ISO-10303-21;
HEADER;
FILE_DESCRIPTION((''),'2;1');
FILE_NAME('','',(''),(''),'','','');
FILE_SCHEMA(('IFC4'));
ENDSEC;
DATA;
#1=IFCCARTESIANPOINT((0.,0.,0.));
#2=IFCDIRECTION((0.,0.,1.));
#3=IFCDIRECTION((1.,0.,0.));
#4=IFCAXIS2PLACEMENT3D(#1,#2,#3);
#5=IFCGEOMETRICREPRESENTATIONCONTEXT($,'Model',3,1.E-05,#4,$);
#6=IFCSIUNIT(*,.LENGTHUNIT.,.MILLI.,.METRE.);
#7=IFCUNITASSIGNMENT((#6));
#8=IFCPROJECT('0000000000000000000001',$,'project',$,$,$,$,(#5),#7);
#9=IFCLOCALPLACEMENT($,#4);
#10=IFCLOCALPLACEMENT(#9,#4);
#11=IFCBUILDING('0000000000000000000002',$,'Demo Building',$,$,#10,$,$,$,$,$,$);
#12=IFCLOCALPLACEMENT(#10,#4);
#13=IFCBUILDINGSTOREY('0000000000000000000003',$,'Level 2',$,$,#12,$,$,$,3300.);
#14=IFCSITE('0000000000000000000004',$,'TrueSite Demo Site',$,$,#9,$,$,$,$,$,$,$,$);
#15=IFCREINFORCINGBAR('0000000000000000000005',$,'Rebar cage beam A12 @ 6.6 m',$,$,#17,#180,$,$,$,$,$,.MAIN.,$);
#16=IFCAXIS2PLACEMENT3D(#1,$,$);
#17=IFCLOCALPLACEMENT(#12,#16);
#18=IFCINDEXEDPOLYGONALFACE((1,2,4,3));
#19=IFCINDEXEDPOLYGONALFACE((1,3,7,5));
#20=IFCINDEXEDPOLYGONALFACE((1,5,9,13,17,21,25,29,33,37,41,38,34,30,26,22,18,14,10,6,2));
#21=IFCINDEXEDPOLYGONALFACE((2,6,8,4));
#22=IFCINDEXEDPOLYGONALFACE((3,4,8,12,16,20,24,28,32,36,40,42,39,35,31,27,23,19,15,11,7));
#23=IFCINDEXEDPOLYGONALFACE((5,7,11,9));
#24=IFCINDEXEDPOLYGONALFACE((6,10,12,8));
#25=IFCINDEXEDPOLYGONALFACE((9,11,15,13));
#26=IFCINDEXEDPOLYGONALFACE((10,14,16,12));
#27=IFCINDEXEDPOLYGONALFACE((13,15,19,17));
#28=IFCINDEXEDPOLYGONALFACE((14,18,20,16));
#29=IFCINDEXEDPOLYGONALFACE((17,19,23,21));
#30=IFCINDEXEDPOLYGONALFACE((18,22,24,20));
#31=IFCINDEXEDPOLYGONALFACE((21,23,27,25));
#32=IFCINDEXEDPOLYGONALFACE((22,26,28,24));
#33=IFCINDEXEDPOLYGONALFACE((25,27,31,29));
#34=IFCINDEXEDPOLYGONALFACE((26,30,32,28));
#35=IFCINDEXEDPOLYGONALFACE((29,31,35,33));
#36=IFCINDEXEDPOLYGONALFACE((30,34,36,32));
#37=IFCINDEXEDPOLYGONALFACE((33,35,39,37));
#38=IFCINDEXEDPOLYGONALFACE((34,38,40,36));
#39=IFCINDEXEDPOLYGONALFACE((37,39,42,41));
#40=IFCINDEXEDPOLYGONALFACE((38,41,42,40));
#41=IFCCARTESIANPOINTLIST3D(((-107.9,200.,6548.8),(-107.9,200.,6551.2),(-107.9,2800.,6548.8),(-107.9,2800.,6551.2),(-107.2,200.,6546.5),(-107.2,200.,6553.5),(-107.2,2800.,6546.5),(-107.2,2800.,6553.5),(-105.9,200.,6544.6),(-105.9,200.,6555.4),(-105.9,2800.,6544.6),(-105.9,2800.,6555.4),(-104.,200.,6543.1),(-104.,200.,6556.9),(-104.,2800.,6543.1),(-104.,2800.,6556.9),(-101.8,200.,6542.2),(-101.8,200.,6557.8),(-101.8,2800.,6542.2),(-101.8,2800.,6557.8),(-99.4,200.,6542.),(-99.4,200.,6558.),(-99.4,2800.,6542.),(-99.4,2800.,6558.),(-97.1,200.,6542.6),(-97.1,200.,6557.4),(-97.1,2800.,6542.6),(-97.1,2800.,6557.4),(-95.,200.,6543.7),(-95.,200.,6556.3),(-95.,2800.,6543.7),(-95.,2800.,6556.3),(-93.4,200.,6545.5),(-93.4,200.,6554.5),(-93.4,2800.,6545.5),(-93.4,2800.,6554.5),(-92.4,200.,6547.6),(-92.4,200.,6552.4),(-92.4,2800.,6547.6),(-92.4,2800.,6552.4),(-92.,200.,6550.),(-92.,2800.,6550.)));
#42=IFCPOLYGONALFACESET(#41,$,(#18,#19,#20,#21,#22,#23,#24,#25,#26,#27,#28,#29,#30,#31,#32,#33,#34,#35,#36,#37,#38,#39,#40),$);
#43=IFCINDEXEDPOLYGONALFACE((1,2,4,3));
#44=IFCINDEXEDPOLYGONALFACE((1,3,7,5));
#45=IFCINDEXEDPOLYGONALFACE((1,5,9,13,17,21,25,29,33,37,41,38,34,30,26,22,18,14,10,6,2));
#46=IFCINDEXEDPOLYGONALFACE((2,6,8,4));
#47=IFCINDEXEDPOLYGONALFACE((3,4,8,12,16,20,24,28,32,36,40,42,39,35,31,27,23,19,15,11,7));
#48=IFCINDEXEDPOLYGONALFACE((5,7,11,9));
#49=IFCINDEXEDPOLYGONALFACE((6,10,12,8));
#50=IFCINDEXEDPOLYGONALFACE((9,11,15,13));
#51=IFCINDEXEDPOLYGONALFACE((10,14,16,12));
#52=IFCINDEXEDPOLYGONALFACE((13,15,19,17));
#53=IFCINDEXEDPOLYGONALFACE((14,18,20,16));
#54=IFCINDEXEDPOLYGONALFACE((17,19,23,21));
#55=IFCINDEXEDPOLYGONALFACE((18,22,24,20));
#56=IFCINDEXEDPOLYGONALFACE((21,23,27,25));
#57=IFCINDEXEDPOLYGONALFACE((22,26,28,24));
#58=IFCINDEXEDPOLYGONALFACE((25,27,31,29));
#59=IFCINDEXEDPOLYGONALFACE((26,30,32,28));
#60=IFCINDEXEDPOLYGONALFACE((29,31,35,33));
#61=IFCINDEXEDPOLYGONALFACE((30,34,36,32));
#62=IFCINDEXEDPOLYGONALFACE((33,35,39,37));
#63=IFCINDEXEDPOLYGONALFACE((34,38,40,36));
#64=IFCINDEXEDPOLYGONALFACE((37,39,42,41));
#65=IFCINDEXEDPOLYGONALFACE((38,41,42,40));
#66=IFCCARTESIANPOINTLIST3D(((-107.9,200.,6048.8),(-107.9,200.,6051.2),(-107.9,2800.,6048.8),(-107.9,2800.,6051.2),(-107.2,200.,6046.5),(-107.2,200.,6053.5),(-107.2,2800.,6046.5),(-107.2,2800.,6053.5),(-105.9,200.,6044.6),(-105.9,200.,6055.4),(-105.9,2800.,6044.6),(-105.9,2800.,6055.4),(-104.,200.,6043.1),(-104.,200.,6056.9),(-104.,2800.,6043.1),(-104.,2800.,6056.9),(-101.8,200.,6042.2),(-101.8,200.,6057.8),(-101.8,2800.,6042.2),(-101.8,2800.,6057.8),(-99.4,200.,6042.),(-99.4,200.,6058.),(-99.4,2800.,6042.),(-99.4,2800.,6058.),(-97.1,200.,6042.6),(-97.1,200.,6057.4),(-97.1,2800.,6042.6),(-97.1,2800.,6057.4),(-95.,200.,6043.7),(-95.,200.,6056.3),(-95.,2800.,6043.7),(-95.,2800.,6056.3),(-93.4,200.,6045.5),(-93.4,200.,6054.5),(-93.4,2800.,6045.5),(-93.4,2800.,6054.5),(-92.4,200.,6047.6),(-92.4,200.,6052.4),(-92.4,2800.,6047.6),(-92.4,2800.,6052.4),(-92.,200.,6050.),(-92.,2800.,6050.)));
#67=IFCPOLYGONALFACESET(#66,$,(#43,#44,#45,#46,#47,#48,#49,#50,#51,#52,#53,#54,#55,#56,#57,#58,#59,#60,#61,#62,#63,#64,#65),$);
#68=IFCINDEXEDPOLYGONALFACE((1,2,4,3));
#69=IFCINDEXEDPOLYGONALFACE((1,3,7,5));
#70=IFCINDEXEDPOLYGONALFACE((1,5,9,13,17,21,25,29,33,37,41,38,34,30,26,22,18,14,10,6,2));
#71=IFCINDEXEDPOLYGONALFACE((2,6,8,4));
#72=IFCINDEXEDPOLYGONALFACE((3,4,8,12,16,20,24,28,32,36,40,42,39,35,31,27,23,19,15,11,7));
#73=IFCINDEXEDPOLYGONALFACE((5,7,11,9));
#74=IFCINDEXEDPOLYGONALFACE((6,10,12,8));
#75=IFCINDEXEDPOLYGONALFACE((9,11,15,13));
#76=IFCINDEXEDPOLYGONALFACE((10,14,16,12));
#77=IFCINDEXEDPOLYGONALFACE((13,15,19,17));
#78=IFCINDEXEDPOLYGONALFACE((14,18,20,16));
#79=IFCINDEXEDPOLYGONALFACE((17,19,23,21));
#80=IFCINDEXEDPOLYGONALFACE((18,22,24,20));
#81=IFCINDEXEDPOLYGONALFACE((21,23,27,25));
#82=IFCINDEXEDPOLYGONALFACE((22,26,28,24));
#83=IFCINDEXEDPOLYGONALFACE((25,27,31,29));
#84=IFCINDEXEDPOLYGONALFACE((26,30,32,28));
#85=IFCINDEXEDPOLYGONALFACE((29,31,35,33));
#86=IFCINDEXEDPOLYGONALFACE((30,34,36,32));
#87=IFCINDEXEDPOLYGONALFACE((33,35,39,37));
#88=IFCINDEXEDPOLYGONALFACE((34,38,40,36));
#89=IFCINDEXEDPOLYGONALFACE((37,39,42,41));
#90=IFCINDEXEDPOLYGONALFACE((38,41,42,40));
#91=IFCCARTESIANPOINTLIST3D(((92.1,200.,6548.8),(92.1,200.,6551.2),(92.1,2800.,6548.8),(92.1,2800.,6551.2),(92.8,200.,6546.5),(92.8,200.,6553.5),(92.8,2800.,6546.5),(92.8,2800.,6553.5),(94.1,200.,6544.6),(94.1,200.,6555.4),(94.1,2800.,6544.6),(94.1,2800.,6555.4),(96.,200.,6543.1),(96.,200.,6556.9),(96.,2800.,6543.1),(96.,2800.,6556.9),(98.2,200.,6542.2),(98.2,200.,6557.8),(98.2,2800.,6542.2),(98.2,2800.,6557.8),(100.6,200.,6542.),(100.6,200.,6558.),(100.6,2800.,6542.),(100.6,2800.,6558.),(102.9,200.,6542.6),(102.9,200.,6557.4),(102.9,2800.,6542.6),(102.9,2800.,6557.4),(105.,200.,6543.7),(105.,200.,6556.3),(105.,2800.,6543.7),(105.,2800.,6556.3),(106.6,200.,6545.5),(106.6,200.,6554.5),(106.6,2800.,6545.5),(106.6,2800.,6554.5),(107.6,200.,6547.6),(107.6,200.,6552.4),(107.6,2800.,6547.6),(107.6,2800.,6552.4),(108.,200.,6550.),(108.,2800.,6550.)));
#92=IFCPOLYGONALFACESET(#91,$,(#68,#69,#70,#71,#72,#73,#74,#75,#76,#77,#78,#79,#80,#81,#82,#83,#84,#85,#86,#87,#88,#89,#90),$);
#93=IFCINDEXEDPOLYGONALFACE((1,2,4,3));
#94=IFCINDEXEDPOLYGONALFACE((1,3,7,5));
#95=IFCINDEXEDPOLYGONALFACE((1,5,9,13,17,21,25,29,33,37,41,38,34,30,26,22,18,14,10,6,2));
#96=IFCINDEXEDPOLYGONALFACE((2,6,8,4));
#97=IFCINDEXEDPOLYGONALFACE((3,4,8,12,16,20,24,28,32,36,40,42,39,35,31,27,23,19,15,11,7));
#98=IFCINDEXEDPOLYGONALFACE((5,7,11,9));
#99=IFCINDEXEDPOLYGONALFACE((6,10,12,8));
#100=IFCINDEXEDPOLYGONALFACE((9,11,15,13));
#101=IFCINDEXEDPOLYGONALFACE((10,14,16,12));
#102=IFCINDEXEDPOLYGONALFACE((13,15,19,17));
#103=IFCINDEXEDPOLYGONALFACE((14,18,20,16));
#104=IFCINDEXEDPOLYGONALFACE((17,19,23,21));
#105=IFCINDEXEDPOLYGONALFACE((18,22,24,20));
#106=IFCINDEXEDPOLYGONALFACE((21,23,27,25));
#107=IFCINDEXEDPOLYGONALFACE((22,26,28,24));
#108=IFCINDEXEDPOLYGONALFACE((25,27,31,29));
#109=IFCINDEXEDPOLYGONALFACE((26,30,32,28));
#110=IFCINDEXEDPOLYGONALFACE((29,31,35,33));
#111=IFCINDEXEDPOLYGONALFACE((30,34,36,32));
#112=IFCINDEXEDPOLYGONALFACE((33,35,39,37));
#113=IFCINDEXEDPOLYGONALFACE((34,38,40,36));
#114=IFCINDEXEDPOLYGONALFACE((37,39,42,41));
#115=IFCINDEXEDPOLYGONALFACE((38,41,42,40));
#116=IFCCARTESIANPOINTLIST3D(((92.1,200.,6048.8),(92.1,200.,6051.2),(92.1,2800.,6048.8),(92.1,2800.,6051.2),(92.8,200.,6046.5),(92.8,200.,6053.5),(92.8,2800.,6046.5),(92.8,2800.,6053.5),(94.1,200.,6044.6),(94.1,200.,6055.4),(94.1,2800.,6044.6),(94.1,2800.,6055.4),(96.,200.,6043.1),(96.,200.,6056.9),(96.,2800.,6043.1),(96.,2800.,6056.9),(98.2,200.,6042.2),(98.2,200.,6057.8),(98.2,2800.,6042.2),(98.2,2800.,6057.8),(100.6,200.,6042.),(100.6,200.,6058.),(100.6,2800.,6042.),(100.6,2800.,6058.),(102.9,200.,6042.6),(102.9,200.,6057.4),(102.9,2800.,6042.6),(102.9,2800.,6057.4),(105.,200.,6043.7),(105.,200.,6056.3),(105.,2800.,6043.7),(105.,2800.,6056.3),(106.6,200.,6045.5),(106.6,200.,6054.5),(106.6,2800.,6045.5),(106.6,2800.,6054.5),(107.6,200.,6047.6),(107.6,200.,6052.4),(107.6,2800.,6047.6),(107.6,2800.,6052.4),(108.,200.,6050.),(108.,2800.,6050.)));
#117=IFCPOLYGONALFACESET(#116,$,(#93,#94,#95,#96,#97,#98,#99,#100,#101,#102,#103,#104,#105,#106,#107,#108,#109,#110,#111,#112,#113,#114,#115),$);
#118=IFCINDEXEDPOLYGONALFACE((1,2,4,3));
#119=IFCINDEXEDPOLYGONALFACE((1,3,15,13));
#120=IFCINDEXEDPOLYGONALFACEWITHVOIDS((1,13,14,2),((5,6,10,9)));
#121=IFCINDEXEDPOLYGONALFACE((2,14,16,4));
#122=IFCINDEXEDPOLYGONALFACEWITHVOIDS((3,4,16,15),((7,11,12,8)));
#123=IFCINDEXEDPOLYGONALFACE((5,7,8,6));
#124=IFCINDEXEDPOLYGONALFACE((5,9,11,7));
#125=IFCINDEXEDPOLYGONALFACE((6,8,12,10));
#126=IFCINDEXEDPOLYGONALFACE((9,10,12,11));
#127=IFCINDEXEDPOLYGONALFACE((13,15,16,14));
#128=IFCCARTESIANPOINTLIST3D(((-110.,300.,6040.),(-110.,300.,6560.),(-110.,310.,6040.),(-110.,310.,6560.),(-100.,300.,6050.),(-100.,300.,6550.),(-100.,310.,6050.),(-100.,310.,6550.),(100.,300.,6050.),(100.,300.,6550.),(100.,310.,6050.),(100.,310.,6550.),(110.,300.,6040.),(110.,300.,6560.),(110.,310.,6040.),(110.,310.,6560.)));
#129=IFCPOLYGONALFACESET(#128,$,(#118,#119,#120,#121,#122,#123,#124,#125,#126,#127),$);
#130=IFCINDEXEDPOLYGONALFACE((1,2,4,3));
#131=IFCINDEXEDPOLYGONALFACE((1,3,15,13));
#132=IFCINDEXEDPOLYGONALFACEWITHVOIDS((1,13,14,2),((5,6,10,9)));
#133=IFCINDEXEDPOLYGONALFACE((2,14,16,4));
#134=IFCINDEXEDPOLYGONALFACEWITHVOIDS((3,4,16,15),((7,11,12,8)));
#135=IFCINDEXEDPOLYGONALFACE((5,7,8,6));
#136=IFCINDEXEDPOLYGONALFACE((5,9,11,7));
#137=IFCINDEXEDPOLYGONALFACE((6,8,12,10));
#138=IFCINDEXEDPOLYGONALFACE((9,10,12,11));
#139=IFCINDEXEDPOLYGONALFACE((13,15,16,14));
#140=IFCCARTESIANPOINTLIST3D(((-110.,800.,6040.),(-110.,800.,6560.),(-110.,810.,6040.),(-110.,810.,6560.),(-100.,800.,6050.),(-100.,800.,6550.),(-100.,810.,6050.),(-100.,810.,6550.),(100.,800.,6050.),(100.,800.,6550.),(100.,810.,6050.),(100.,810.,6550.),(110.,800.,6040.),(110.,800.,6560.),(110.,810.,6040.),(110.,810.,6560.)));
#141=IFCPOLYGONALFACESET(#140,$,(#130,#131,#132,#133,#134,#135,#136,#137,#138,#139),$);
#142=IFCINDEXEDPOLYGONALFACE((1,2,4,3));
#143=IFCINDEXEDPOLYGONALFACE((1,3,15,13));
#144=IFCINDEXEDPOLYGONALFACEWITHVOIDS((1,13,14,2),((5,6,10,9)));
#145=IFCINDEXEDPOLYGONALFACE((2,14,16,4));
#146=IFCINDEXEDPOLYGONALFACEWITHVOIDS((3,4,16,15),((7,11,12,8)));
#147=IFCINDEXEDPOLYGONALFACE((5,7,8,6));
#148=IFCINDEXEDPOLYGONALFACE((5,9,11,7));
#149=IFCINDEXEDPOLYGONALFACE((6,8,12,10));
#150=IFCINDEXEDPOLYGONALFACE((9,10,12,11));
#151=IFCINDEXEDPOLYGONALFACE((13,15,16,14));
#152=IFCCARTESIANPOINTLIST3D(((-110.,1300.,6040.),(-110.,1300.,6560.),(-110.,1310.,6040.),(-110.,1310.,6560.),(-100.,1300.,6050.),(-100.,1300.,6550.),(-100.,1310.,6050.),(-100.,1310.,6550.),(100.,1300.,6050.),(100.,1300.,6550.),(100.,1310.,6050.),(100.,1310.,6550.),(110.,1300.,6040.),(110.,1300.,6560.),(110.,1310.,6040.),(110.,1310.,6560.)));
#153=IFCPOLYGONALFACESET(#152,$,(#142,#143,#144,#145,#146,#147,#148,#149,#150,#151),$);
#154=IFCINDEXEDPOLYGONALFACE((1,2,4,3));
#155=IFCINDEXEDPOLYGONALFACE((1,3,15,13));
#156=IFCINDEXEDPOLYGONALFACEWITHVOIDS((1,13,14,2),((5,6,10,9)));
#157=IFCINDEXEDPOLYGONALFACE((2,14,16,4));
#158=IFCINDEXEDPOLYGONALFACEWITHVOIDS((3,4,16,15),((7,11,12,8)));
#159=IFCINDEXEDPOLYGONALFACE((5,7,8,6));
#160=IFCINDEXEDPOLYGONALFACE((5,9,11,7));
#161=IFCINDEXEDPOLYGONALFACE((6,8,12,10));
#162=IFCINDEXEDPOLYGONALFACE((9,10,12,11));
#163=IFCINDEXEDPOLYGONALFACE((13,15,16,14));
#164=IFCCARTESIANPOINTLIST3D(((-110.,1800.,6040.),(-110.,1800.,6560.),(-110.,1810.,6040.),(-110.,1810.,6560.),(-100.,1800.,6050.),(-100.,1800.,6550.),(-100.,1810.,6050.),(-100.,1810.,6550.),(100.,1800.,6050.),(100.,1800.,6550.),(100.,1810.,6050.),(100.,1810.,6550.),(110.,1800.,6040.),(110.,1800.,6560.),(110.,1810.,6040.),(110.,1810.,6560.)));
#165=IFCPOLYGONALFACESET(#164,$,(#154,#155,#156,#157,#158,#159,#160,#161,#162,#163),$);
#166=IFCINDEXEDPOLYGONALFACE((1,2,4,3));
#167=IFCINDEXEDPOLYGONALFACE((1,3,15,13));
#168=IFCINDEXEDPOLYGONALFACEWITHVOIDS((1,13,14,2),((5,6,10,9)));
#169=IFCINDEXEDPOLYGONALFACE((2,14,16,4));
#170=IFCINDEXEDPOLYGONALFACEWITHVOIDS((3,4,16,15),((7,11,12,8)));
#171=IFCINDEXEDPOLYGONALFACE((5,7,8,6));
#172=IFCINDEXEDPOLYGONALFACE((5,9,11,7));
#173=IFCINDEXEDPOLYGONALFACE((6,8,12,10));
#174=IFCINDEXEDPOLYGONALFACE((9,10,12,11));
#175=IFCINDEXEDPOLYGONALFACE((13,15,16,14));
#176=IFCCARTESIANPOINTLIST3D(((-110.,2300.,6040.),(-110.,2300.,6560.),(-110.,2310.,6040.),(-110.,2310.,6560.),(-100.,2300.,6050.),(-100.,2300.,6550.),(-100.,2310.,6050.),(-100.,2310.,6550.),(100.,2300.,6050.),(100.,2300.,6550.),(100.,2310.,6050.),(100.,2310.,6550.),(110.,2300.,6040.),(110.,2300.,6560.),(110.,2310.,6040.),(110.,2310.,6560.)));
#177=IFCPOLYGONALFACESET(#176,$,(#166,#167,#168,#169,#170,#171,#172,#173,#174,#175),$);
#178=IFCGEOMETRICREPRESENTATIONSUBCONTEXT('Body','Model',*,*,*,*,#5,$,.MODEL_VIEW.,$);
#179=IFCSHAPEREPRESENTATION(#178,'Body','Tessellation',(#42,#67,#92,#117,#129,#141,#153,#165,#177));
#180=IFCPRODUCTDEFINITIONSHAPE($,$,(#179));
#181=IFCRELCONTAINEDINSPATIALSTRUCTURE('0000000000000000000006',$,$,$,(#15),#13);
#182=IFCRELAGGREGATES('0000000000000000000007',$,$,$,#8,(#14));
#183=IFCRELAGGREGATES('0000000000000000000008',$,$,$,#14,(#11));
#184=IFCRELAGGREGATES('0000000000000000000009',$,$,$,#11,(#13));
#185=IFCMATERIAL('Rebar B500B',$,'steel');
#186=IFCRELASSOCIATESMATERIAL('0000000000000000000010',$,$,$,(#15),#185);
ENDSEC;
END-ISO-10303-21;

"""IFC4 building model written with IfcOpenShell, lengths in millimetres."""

from ifc_helpers import new_model, si_unit, frame, origin_with_axes, place, context, subcontext, project, spatial, hollow_rectangle, circle, extrude, material, element, save


model = new_model("IFC4")

# Units and contexts
model_context = context("Model", 3, precision=1e-05, world=origin_with_axes())
body_context = subcontext(model_context, "Body", "Model", "MODEL_VIEW")
ifc_project = project(units=[si_unit("LENGTHUNIT", "METRE", prefix="MILLI")], contexts=[model_context])

# Site, building, storey
site_placement = place(None, origin_with_axes())
site = spatial("IfcSite", under=ifc_project, at=site_placement, Name="TrueSite Demo Site")
building_placement = place(site_placement, origin_with_axes())
building = spatial("IfcBuilding", under=site, at=building_placement, Name="Demo Building")
storey_placement = place(building_placement, origin_with_axes())
storey = spatial("IfcBuildingStorey", under=building, at=storey_placement, Name="Level 2", Elevation=3300.0)

# Reinforcing bar
ifc_material_1 = material(Name="Rebar B500B", Category="steel")
for number, where, z_axis, x_axis, name in (
    (1, (0.0, 200.0, 6300.0), (0.0, 1.0, 0.0), (1.0, 0.0, 0.0), "Rebar cage beam A12 @ 6.6 m"),
):
    element("IfcReinforcingBar", number, at=place(storey_placement, frame(where, z_axis=z_axis, x_axis=x_axis)), inside=storey, material=ifc_material_1, Name=name, PredefinedType="MAIN", context=body_context, shape_type="SweptSolid", body=[
        extrude(circle(Radius=8.0), frame((-100.0, -250.0, 0.0)), (0.0, 0.0, 1.0), 2600.0),
        extrude(circle(Radius=8.0), frame((-100.0, 250.0, 0.0)), (0.0, 0.0, 1.0), 2600.0),
        extrude(circle(Radius=8.0), frame((100.0, -250.0, 0.0)), (0.0, 0.0, 1.0), 2600.0),
        extrude(circle(Radius=8.0), frame((100.0, 250.0, 0.0)), (0.0, 0.0, 1.0), 2600.0),
        extrude(hollow_rectangle(XDim=220.0, YDim=520.0, WallThickness=10.0), frame((0.0, 0.0, 100.0)), (0.0, 0.0, 1.0), 10.0),
        extrude(hollow_rectangle(XDim=220.0, YDim=520.0, WallThickness=10.0), frame((0.0, 0.0, 600.0)), (0.0, 0.0, 1.0), 10.0),
        extrude(hollow_rectangle(XDim=220.0, YDim=520.0, WallThickness=10.0), frame((0.0, 0.0, 1100.0)), (0.0, 0.0, 1.0), 10.0),
        extrude(hollow_rectangle(XDim=220.0, YDim=520.0, WallThickness=10.0), frame((0.0, 0.0, 1600.0)), (0.0, 0.0, 1.0), 10.0),
        extrude(hollow_rectangle(XDim=220.0, YDim=520.0, WallThickness=10.0), frame((0.0, 0.0, 2100.0)), (0.0, 0.0, 1.0), 10.0),
    ])

save(model, "model.ifc")
